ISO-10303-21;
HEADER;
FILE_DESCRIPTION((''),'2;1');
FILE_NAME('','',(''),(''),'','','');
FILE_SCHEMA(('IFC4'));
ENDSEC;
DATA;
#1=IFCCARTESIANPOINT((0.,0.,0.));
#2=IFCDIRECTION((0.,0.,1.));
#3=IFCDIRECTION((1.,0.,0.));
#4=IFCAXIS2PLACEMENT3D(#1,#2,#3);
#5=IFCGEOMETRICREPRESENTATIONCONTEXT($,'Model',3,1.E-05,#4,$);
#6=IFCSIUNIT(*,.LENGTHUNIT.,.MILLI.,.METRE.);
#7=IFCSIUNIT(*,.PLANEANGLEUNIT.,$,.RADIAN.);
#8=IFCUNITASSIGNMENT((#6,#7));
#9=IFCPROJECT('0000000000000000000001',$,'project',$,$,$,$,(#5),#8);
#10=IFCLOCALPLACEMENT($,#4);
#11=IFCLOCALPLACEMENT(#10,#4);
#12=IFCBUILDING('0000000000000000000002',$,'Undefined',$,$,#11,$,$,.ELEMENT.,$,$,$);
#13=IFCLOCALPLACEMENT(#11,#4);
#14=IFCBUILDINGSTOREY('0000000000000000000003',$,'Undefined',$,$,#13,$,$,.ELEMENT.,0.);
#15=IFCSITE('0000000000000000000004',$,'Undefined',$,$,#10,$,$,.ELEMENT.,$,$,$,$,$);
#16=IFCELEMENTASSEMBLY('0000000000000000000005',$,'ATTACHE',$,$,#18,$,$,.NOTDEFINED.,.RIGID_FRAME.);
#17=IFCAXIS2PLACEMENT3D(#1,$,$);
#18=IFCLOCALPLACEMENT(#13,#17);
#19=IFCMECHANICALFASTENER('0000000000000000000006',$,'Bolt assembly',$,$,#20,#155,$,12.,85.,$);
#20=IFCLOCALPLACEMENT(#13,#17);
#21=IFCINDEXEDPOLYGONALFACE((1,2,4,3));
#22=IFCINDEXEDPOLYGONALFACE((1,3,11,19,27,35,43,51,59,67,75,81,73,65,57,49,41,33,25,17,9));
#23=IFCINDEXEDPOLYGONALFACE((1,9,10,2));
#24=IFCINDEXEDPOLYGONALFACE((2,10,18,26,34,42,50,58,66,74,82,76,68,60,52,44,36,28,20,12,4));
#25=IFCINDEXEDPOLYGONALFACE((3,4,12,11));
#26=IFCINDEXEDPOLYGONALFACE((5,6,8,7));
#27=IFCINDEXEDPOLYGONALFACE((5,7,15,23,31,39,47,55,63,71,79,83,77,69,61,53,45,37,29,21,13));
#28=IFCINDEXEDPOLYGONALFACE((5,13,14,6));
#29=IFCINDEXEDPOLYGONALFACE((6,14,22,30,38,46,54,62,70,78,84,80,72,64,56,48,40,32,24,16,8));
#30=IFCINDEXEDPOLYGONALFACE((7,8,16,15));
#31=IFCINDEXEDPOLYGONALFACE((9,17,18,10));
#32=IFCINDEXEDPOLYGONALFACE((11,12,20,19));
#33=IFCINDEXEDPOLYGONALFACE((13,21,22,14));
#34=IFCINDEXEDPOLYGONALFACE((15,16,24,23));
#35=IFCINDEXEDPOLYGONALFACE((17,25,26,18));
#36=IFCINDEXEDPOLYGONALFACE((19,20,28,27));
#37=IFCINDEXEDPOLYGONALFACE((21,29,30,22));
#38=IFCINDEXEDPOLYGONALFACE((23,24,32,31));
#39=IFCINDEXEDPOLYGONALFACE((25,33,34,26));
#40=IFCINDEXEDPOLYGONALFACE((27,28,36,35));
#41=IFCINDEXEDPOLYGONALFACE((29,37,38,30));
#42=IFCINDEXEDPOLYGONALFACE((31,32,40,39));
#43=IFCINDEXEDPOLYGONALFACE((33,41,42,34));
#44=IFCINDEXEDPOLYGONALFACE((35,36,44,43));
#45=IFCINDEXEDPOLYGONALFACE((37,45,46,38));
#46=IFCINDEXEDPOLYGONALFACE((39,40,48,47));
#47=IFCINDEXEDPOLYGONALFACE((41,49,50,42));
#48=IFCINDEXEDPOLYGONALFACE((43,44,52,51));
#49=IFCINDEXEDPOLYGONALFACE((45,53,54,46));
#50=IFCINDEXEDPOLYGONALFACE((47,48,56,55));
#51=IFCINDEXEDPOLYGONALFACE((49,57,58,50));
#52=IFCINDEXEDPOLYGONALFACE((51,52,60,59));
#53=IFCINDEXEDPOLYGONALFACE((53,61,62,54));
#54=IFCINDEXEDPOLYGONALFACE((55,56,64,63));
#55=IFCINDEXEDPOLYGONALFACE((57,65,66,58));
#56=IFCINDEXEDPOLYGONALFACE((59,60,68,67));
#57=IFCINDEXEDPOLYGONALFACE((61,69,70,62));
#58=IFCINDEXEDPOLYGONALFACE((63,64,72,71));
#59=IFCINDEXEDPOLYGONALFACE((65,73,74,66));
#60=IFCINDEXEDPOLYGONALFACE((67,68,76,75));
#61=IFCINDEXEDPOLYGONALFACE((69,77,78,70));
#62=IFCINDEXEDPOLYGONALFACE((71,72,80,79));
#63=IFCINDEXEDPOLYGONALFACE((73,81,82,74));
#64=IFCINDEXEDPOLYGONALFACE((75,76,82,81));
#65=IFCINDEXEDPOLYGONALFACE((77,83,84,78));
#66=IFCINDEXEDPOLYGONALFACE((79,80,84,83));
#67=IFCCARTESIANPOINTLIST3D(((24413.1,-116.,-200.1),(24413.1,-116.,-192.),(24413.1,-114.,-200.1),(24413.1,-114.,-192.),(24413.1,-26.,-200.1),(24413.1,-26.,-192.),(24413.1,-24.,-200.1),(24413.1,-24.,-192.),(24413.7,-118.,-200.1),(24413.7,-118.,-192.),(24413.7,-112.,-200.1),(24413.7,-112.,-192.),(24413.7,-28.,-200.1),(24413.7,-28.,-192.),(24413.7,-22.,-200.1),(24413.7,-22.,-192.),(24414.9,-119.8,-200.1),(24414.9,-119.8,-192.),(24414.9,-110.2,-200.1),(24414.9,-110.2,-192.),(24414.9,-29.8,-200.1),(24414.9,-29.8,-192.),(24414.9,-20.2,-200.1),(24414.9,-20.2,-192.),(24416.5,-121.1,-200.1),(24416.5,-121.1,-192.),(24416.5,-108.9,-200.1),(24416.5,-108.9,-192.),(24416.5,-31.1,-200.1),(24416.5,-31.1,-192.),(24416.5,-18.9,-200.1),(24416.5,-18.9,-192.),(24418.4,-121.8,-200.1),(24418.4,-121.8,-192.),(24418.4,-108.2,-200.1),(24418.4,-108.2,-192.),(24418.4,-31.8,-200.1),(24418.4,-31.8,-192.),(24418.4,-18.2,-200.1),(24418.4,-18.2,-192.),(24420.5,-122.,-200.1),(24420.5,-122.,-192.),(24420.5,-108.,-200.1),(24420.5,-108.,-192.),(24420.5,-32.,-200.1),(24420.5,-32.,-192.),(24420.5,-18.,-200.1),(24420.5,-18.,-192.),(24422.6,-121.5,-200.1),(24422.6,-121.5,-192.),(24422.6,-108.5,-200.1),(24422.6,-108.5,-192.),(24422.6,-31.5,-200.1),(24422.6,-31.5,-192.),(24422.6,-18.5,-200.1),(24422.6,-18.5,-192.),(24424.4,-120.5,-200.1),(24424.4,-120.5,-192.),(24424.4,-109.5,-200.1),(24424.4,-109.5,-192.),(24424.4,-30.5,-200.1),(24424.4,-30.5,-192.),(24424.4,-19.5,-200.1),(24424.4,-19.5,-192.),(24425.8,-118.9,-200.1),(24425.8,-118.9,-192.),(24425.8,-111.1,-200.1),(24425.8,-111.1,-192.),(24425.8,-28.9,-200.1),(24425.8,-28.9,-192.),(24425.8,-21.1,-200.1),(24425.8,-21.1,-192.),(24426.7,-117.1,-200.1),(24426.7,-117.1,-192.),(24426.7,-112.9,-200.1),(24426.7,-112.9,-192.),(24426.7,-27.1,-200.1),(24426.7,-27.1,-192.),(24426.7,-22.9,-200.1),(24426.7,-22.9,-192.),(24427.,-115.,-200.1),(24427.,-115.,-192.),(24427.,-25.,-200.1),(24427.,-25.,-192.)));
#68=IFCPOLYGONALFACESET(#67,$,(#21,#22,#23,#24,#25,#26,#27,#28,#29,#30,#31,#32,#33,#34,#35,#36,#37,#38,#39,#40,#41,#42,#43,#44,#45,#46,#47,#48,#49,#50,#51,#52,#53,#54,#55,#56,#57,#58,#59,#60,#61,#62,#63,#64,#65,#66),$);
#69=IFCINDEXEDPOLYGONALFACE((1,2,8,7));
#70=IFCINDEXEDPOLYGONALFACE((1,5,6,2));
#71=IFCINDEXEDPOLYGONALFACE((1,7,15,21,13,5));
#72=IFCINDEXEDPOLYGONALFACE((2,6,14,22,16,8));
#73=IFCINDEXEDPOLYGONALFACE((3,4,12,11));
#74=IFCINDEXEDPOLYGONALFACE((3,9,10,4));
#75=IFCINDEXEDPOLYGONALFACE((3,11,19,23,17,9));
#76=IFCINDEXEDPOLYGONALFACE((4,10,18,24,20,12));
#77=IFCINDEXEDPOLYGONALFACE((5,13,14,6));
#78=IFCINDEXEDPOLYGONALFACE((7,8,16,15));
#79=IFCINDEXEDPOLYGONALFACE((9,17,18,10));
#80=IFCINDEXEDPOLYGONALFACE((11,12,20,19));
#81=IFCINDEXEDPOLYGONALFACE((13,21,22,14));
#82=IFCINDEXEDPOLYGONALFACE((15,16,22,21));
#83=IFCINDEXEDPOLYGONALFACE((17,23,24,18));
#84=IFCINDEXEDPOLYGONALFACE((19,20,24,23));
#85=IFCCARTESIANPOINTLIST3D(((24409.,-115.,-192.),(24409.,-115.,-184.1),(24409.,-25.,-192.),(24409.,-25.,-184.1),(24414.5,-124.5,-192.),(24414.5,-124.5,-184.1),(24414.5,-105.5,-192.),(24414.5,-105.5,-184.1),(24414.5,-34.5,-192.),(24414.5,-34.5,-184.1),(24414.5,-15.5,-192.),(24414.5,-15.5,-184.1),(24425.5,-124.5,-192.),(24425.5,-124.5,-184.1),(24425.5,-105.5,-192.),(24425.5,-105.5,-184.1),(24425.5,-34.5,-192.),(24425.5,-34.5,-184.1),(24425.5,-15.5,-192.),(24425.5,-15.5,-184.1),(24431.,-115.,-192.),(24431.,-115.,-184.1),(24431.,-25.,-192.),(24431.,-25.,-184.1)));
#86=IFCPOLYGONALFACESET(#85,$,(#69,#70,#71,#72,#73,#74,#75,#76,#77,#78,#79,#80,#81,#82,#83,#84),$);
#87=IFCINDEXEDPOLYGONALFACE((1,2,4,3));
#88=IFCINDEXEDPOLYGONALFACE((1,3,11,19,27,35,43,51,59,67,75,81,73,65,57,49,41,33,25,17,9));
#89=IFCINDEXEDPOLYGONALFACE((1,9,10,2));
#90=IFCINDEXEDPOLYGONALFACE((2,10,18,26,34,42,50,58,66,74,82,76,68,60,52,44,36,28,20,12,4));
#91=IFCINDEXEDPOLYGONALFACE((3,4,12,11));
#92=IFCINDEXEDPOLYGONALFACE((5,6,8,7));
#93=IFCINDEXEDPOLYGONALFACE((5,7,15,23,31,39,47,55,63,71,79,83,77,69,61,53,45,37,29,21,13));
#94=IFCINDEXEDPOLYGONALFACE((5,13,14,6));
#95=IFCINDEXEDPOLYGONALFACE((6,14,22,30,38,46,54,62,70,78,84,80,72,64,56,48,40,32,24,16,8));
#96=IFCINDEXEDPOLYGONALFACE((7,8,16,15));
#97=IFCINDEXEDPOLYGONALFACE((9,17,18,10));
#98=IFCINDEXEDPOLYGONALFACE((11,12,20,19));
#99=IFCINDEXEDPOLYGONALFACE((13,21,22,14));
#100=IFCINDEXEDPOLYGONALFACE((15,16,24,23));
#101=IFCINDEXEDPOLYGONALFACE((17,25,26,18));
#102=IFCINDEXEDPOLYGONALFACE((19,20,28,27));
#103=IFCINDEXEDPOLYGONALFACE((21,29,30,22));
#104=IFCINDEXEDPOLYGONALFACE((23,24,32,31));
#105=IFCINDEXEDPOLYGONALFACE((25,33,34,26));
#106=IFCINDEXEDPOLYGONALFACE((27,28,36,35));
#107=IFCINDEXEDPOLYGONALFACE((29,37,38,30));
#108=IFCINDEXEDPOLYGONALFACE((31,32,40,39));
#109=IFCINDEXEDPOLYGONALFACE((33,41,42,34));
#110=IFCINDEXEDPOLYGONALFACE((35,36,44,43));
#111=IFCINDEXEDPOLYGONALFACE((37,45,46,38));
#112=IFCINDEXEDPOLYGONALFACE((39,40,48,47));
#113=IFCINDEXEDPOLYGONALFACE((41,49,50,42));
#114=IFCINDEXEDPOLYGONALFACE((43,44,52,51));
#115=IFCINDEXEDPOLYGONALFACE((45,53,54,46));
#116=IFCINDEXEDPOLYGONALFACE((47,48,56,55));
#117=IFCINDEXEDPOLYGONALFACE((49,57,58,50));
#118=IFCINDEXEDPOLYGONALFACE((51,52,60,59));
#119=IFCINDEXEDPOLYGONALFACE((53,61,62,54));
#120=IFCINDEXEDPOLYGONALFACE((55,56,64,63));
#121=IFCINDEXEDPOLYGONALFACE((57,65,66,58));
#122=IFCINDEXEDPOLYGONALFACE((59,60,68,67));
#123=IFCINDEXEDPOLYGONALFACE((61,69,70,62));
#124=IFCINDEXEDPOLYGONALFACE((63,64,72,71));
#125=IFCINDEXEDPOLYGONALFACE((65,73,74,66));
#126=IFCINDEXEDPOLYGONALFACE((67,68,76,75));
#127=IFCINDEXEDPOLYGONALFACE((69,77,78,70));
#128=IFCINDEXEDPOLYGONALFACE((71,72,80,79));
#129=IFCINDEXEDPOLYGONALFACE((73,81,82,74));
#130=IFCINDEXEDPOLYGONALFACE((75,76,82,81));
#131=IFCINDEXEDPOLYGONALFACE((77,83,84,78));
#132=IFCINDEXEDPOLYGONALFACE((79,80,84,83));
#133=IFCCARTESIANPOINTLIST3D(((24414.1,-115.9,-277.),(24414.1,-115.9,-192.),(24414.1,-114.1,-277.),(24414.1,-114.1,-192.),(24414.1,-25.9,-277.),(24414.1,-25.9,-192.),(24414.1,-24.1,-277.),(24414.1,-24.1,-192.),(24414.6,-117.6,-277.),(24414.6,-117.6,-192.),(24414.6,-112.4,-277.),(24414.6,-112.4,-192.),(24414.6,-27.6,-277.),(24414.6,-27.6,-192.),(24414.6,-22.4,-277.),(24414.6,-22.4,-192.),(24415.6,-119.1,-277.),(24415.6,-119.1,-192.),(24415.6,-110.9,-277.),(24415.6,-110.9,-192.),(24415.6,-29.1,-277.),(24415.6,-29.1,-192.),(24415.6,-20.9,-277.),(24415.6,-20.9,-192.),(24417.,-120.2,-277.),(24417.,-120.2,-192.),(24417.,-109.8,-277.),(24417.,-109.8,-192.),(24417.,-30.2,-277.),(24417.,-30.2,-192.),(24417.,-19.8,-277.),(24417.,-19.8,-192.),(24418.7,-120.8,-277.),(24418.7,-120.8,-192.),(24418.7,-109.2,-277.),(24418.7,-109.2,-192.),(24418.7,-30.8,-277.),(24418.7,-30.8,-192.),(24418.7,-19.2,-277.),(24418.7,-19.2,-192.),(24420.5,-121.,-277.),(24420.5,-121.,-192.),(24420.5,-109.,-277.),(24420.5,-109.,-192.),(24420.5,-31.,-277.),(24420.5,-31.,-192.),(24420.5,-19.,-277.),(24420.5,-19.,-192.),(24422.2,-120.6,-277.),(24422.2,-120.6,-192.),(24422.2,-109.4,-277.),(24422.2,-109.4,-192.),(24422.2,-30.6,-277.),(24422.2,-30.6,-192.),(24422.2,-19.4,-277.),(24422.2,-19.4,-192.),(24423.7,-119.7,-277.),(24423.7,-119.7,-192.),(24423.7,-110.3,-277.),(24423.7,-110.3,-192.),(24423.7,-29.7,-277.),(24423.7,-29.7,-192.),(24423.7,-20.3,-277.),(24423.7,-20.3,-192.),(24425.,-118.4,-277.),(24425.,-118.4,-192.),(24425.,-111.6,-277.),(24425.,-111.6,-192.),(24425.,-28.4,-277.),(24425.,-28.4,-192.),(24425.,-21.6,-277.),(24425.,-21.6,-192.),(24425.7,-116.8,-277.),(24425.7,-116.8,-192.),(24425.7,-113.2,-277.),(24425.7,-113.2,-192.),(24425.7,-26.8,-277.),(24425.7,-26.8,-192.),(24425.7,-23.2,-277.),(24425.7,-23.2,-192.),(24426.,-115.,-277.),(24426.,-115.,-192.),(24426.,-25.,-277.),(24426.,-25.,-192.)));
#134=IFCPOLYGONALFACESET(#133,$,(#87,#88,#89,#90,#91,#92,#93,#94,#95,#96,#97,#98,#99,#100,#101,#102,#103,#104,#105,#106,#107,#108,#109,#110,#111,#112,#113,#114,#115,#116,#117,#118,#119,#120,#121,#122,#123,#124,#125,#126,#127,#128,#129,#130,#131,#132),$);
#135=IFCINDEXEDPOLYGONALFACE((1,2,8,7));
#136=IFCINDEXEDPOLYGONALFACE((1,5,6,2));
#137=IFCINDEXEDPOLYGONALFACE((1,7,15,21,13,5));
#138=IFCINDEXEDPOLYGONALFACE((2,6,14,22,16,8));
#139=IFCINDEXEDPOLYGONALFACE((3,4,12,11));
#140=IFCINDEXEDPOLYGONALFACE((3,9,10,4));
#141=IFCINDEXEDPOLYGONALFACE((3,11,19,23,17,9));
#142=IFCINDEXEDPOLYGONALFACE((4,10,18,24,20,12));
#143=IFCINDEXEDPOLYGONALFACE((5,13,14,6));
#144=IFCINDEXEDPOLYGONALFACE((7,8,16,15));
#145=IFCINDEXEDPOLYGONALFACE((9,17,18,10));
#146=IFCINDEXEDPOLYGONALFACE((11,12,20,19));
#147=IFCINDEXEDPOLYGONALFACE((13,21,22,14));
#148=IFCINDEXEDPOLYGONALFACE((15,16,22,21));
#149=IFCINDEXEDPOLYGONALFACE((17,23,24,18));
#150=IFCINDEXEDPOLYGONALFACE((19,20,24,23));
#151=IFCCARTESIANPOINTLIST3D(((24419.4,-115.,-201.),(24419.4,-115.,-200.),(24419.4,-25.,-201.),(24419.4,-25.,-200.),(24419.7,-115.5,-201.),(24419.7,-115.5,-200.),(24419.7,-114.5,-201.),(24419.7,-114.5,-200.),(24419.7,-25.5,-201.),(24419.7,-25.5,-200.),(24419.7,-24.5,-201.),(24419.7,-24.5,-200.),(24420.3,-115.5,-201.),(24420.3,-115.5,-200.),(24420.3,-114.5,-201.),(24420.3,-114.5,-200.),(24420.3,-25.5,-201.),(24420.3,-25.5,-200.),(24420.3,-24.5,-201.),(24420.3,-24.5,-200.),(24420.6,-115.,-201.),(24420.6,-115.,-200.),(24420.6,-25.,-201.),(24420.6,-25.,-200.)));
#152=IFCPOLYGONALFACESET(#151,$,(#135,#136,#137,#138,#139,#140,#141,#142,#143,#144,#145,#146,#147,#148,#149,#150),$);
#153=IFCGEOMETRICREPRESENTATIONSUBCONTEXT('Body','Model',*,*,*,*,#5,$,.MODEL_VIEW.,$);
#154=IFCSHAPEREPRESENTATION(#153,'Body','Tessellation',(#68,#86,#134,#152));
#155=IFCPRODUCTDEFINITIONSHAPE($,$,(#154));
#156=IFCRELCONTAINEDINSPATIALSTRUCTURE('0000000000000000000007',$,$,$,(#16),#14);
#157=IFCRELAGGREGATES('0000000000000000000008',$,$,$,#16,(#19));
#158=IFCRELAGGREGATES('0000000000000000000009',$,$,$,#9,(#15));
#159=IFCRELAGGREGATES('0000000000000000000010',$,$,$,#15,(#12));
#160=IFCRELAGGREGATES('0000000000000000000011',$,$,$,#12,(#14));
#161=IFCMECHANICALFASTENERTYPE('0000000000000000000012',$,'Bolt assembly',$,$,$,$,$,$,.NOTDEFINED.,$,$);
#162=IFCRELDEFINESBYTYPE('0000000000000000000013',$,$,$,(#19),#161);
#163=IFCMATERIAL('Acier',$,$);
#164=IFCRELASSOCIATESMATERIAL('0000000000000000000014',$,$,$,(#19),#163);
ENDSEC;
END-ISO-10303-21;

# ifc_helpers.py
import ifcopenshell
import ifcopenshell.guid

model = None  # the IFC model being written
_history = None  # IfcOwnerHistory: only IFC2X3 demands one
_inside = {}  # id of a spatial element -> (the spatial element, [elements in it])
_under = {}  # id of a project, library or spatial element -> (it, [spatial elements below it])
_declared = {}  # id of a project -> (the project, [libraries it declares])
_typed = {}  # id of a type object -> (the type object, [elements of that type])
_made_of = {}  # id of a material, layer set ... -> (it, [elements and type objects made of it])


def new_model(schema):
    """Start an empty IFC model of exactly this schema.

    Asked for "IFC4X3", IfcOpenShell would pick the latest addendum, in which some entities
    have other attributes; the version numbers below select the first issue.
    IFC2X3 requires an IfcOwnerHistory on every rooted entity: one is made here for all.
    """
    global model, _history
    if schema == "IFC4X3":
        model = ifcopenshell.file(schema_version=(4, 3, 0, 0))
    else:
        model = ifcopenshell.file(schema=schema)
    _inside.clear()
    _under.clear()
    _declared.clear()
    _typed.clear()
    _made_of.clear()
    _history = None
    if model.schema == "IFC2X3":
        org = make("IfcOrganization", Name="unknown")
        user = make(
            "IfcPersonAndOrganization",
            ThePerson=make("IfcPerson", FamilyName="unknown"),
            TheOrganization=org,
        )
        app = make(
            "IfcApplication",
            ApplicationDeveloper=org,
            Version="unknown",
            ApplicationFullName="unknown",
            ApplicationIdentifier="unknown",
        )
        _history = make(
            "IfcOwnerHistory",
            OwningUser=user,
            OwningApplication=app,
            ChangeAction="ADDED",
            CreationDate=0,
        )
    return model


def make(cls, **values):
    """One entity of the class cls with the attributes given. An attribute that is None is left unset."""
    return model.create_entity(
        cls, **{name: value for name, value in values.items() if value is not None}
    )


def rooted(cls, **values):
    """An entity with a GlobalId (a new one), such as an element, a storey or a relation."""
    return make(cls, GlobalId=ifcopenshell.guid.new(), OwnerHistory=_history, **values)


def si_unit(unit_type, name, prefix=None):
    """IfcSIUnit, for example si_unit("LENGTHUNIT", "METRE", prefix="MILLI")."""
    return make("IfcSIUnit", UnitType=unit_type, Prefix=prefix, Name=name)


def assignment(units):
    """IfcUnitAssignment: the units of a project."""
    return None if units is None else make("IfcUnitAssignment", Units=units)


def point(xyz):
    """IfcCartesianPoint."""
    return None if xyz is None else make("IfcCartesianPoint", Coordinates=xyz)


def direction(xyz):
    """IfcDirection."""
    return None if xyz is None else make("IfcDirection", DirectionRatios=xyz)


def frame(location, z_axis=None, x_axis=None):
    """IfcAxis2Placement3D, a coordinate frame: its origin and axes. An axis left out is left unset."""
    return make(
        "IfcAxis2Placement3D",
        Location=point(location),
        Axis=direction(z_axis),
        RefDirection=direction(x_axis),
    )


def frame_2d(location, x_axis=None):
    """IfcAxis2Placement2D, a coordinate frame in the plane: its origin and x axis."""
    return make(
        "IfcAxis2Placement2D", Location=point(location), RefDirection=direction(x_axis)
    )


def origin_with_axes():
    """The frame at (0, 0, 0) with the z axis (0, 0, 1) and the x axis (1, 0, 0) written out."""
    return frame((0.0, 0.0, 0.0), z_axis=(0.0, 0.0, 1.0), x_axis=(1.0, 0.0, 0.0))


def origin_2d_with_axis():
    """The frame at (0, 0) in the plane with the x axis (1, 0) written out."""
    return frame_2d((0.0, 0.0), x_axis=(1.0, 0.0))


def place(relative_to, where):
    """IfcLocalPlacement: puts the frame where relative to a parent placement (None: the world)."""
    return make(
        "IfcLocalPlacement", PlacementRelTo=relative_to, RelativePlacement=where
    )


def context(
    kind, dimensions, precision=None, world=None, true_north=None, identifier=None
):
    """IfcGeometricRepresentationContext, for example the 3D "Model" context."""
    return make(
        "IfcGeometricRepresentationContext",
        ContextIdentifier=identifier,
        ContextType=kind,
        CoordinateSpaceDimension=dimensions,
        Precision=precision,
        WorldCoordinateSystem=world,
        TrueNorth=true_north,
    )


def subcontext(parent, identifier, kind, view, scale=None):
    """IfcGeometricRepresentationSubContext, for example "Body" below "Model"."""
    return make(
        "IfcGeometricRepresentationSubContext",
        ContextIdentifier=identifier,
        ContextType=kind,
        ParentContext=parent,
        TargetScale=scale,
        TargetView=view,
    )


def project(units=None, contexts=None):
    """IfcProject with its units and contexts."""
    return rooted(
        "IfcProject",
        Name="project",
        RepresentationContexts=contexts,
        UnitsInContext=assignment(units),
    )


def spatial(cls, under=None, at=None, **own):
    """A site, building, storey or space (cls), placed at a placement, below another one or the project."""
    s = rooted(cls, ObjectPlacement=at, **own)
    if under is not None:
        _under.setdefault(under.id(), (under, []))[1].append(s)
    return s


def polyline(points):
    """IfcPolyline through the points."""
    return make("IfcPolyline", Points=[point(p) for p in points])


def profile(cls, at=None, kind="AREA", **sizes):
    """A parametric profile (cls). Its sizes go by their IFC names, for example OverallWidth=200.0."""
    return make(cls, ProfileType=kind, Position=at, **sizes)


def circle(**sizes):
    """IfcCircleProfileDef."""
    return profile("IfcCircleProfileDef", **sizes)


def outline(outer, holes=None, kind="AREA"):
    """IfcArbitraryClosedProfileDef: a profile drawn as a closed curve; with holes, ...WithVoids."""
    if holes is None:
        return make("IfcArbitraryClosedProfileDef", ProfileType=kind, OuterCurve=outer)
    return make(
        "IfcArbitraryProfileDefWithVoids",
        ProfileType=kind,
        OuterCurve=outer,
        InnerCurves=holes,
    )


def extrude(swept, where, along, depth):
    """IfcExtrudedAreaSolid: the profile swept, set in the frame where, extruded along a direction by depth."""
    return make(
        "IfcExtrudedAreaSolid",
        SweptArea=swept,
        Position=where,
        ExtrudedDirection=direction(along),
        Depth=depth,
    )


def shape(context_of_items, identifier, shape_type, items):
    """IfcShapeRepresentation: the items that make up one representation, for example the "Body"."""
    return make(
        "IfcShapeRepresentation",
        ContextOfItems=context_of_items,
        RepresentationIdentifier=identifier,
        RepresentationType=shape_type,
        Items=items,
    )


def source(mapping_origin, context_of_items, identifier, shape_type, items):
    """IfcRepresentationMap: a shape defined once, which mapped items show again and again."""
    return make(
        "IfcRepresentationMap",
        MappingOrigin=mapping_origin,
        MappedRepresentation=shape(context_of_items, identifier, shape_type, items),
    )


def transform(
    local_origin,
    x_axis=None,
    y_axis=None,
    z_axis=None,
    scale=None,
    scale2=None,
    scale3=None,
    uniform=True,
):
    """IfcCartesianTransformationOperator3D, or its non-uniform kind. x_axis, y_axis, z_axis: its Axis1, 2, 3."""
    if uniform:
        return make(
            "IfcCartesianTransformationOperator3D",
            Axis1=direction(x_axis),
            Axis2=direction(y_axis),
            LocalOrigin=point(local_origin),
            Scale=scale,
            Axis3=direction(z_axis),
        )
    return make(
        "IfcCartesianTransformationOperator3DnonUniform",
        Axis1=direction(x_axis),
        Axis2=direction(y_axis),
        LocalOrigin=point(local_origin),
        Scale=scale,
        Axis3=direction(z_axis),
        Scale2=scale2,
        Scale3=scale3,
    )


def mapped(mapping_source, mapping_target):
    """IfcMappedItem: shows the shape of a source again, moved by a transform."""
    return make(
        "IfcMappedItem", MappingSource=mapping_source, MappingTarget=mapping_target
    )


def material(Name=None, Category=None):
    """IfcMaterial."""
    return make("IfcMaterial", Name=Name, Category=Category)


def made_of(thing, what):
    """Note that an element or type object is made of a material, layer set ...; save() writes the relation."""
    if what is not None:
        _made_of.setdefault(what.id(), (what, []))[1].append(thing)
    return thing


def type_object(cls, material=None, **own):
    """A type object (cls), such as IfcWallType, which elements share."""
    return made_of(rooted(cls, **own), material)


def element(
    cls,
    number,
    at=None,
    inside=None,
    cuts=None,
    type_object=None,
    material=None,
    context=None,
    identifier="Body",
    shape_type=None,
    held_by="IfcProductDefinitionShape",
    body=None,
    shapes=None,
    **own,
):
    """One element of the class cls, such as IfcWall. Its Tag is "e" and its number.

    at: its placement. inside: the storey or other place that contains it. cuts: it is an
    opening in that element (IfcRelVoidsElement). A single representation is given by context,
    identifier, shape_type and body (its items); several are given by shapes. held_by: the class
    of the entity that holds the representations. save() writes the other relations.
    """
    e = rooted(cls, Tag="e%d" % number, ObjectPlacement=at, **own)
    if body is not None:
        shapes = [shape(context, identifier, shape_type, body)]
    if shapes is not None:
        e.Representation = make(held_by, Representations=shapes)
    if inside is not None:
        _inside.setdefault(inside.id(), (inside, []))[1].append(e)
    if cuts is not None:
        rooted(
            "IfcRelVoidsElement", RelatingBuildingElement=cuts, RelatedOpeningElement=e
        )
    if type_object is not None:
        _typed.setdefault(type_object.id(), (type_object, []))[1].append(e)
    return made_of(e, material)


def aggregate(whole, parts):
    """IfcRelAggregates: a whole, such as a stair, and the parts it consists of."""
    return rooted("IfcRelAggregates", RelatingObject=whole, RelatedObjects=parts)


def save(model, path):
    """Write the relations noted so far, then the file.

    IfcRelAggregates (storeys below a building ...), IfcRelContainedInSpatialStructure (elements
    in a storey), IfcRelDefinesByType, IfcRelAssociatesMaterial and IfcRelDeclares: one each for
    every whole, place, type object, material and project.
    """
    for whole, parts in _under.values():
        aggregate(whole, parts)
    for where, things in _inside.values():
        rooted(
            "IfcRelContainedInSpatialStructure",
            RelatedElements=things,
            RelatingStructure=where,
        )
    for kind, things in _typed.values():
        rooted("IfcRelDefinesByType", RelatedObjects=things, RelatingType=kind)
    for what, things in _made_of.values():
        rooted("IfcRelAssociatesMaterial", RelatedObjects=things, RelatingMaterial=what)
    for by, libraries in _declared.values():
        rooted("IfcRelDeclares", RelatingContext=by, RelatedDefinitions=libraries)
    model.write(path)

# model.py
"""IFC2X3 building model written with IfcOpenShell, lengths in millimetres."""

from ifc_helpers import new_model, si_unit, frame, origin_with_axes, origin_2d_with_axis, place, context, subcontext, project, spatial, polyline, circle, outline, extrude, source, transform, mapped, material, type_object, element, aggregate, save


model = new_model("IFC2X3")

# Units and contexts
model_context = context("Model", 3, precision=1e-05, world=origin_with_axes())
body_context = subcontext(model_context, "Body", "Model", "MODEL_VIEW")
ifc_project = project(units=[si_unit("LENGTHUNIT", "METRE", prefix="MILLI"), si_unit("PLANEANGLEUNIT", "RADIAN")], contexts=[model_context])

# Site, building, storey
site_placement = place(None, origin_with_axes())
site = spatial("IfcSite", under=ifc_project, at=site_placement, Name="Undefined", CompositionType="ELEMENT")
building_placement = place(site_placement, origin_with_axes())
building = spatial("IfcBuilding", under=site, at=building_placement, Name="Undefined", CompositionType="ELEMENT")
storey_placement = place(building_placement, origin_with_axes())
storey = spatial("IfcBuildingStorey", under=building, at=storey_placement, Name="Undefined", CompositionType="ELEMENT", Elevation=0.0)

# Element assembly
assembly_1_placement = place(storey_placement, origin_with_axes())
assembly_1 = element("IfcElementAssembly", 1, at=assembly_1_placement, inside=storey, Name="ATTACHE", AssemblyPlace="NOTDEFINED", PredefinedType="RIGID_FRAME")

# Mechanical fastener
mechanical_fastener_type = type_object("IfcMechanicalFastenerType", Name="Bolt assembly")
ifc_material_1 = material(Name="Acier")
shared_shape_1 = source(origin_with_axes(), body_context, "Body", "SweptSolid", [
    extrude(circle(Radius=7.0, at=origin_2d_with_axis()), frame((0.0, -8.0, 0.0), z_axis=(0.0, 1.0, 0.0), x_axis=(1.0, 0.0, 0.0)), (0.0, 0.0, 1.0), 8.1),
    extrude(outline(polyline([(11.0, 0.0), (5.5, 9.5), (-5.5, 9.5), (-11.0, 0.0), (-5.5, -9.5), (5.5, -9.5), (11.0, 0.0)])), frame((0.0, -15.9, 0.0), z_axis=(0.0, 1.0, 0.0), x_axis=(1.0, 0.0, 0.0)), (0.0, 0.0, 1.0), 7.9),
    extrude(circle(Radius=6.0, at=origin_2d_with_axis()), frame((0.0, -8.0, 0.0), z_axis=(0.0, 1.0, 0.0), x_axis=(1.0, 0.0, 0.0)), (0.0, 0.0, 1.0), 85.0),
    extrude(outline(polyline([(0.6, 0.0), (0.3, 0.5), (-0.3, 0.5), (-0.6, 0.0), (-0.3, -0.5), (0.3, -0.5), (0.6, 0.0)])), frame((0.0, 0.0, 0.0), z_axis=(0.0, 1.0, 0.0), x_axis=(1.0, 0.0, 0.0)), (0.0, 0.0, 1.0), 1.0),
])
mechanical_fastener_1_placement = place(assembly_1_placement, frame((24420.0, -70.0, -200.0), z_axis=(0.0, 1.0, 0.0), x_axis=(1.0, 0.0, 0.0)))
mechanical_fastener_1 = element("IfcMechanicalFastener", 2, at=mechanical_fastener_1_placement, type_object=mechanical_fastener_type, material=ifc_material_1, Name="Bolt assembly", NominalDiameter=12.0, NominalLength=85.0, context=body_context, shape_type="MappedRepresentation", body=[
    mapped(shared_shape_1, transform((0.0, 0.0, 45.0))),
    mapped(shared_shape_1, transform((0.0, 0.0, -45.0))),
])
aggregate(assembly_1, [mechanical_fastener_1])

save(model, "model.ifc")
